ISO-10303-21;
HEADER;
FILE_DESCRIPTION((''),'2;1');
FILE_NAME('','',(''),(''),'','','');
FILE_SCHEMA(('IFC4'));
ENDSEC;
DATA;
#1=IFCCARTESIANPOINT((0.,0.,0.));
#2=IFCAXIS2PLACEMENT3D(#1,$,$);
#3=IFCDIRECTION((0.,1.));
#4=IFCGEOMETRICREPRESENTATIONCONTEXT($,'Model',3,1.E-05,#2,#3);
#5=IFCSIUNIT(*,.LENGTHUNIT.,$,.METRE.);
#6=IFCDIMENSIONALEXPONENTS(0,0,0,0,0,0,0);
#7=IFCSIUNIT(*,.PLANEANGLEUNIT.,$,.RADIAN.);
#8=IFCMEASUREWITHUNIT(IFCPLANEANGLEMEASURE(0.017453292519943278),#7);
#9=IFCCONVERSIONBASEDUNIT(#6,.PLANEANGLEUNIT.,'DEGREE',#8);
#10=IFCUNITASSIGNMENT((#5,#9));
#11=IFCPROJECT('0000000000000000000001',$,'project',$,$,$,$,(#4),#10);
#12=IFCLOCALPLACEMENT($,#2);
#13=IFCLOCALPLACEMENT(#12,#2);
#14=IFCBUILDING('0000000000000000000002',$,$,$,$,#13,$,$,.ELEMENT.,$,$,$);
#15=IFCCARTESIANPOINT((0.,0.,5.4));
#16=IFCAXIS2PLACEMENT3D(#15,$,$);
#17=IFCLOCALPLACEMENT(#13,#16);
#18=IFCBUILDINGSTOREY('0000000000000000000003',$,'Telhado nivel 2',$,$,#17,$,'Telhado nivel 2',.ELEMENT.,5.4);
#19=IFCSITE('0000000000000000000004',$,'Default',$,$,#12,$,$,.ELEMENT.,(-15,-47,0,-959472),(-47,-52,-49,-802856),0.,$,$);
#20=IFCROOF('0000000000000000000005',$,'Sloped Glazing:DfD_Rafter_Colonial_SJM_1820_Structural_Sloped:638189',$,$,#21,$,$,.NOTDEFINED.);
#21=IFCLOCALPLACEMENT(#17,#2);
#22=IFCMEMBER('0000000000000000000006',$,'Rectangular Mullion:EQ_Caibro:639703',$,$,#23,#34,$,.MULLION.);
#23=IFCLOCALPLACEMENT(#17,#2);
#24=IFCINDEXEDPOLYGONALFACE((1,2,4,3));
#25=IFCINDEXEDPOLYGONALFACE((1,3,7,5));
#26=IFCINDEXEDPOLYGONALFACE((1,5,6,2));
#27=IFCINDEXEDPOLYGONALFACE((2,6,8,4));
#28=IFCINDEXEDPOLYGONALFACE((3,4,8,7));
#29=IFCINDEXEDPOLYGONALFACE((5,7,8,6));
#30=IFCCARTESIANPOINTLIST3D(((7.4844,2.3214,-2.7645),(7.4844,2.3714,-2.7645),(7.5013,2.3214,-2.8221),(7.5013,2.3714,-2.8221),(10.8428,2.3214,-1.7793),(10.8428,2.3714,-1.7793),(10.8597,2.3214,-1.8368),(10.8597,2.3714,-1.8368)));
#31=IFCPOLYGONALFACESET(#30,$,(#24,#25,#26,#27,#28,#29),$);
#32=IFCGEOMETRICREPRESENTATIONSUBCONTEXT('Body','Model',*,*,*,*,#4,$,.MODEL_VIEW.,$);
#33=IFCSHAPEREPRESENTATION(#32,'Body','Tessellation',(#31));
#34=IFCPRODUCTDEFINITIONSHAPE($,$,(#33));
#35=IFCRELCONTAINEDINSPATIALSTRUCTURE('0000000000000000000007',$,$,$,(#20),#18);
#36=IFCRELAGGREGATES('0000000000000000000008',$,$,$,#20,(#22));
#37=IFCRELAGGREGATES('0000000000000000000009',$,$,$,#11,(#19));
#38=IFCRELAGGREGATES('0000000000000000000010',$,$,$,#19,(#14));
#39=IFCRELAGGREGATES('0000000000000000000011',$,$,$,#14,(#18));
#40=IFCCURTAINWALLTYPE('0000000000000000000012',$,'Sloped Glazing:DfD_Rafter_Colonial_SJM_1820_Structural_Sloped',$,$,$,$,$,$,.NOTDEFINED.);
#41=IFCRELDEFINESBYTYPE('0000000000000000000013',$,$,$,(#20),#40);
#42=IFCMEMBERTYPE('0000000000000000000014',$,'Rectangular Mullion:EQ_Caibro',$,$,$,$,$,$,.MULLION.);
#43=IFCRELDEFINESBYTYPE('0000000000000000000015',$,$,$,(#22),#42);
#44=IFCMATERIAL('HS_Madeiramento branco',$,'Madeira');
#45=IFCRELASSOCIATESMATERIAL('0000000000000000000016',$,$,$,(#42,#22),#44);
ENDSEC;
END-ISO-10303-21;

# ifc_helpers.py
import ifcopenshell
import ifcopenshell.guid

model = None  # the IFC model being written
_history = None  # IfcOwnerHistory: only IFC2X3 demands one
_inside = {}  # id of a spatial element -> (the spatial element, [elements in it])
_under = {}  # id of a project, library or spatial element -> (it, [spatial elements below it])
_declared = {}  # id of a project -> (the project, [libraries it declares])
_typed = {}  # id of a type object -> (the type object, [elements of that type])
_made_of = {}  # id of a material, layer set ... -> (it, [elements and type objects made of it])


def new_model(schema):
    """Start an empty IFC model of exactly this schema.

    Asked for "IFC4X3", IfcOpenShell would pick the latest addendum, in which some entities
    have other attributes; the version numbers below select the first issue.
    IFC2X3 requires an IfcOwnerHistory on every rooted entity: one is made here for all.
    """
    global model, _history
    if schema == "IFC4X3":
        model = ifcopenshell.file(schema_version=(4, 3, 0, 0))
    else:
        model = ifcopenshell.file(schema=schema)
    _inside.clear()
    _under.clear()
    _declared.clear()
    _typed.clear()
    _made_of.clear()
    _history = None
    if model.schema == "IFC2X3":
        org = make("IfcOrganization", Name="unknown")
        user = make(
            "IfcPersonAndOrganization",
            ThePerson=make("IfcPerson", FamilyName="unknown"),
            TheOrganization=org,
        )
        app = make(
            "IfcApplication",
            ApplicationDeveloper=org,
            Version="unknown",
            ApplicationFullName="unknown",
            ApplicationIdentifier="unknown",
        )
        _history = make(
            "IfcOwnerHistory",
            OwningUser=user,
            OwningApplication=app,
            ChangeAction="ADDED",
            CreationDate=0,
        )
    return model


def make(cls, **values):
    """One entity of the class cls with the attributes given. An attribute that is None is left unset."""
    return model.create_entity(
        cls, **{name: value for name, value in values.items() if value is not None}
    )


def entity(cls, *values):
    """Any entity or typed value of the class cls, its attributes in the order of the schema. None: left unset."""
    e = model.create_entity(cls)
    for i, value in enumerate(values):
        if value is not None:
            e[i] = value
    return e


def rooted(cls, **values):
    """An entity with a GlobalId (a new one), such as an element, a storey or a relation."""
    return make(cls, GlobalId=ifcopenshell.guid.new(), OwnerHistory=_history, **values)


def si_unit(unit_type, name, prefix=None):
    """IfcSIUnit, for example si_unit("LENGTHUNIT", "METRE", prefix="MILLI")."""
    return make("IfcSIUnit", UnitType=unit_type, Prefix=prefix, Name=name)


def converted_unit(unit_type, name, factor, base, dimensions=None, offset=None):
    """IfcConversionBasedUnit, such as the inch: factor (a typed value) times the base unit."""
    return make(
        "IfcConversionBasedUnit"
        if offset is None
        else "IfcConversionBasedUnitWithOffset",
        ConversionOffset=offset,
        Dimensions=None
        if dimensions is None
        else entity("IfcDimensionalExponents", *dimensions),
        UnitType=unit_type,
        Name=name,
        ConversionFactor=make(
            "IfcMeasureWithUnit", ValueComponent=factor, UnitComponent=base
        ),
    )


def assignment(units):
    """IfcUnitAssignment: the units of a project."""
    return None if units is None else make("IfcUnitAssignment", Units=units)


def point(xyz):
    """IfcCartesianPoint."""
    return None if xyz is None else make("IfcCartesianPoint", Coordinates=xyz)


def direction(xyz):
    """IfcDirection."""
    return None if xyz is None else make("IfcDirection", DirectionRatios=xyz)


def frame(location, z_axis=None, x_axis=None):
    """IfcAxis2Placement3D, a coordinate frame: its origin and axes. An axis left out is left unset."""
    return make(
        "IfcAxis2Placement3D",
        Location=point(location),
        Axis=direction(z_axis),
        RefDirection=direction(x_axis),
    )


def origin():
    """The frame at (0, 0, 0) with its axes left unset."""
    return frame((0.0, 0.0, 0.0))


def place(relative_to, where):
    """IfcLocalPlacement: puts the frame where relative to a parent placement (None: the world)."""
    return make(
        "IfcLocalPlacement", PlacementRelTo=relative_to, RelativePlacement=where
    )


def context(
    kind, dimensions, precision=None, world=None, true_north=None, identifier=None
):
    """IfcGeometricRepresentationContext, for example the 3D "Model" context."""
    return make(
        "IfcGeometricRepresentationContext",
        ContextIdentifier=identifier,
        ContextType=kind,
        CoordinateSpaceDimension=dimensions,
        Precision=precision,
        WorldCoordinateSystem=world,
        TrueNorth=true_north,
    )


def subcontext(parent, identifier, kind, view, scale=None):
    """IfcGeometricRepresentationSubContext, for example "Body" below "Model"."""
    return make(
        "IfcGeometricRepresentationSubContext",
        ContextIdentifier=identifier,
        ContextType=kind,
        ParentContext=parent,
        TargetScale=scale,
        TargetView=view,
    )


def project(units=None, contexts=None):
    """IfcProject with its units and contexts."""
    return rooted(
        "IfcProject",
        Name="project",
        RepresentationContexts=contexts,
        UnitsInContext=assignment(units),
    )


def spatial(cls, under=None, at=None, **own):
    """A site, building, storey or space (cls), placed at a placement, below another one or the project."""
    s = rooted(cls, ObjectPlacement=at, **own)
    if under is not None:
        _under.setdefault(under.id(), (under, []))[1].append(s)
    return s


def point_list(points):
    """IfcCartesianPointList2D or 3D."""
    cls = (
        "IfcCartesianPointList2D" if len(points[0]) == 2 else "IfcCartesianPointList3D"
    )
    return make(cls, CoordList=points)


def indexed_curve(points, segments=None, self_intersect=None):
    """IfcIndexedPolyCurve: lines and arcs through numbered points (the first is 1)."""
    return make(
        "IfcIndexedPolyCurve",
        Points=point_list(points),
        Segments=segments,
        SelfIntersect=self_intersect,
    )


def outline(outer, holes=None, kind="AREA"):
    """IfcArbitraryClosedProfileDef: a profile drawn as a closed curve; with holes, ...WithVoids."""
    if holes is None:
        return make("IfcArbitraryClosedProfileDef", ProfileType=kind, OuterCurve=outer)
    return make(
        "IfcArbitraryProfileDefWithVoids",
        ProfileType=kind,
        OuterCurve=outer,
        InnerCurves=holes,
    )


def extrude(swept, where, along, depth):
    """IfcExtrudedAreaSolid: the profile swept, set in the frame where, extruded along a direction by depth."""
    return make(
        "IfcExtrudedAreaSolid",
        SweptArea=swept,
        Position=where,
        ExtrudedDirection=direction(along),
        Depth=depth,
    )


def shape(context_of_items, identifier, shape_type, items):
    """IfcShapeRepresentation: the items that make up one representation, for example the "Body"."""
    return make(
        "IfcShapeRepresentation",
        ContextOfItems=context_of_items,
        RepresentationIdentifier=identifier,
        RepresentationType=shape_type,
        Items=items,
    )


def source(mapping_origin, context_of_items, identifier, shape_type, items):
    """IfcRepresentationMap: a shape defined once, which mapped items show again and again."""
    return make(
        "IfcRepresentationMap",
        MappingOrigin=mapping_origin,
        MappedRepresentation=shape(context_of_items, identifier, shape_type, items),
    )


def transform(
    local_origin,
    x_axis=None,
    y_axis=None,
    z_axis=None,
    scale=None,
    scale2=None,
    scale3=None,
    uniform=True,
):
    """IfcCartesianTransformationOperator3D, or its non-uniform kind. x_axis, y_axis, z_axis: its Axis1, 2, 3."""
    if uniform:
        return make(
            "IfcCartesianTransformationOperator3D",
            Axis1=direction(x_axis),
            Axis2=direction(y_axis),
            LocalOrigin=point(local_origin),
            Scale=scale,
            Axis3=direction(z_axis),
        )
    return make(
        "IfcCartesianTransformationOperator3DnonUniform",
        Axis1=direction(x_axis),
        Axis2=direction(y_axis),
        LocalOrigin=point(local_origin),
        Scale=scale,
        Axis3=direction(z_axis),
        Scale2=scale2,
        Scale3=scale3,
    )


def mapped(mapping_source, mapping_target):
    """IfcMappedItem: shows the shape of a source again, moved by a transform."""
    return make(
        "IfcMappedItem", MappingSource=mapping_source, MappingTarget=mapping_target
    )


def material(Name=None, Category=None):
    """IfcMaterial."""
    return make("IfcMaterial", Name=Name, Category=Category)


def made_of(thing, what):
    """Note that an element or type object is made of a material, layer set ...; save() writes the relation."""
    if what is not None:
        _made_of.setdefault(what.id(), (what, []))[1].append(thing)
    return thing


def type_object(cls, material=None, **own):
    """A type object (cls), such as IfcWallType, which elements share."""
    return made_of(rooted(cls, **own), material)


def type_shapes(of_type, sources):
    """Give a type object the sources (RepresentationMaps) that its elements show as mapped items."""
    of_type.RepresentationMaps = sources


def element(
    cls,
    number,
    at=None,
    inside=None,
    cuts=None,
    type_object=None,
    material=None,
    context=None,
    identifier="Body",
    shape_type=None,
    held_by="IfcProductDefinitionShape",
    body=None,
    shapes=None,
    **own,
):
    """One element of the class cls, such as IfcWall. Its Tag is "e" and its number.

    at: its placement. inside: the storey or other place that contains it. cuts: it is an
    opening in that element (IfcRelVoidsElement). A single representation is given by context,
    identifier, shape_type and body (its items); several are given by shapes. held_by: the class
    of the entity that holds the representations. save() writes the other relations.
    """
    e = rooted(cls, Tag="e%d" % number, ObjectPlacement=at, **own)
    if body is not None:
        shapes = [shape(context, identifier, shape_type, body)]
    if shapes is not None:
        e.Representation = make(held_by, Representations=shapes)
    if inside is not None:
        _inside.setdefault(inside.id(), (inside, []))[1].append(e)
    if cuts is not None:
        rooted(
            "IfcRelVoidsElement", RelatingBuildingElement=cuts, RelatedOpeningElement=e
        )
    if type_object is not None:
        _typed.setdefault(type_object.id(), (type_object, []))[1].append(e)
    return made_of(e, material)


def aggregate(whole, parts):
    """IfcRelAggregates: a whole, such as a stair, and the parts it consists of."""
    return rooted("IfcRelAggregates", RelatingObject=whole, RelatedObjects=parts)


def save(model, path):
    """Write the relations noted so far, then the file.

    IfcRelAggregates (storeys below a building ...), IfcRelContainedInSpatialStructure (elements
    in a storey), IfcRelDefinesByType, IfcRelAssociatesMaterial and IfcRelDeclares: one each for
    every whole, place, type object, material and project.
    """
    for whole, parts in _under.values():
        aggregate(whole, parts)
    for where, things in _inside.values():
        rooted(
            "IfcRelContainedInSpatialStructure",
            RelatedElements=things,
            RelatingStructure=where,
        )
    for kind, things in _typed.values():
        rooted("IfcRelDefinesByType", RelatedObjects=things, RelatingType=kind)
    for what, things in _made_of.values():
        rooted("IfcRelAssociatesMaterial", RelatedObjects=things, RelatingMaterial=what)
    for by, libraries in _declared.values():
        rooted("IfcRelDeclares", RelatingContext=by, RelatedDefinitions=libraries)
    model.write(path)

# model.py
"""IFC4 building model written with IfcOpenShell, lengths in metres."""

from ifc_helpers import new_model, entity, si_unit, converted_unit, direction, frame, origin, place, context, subcontext, project, spatial, indexed_curve, outline, extrude, source, transform, mapped, material, type_object, type_shapes, element, aggregate, save


model = new_model("IFC4")

# Units and contexts
model_context = context("Model", 3, precision=1e-05, world=origin(), true_north=direction((0.0, 1.0)))
body_context = subcontext(model_context, "Body", "Model", "MODEL_VIEW")
ifc_project = project(units=[si_unit("LENGTHUNIT", "METRE"), converted_unit("PLANEANGLEUNIT", "DEGREE", entity("IfcPlaneAngleMeasure", 0.017453292519943278), si_unit("PLANEANGLEUNIT", "RADIAN"), dimensions=[0, 0, 0, 0, 0, 0, 0])], contexts=[model_context])

# Site, building, storey
site_placement = place(None, origin())
site = spatial("IfcSite", under=ifc_project, at=site_placement, Name="Default", CompositionType="ELEMENT", RefLatitude=(-15, -47, 0, -959472), RefLongitude=(-47, -52, -49, -802856), RefElevation=0.0)
building_placement = place(site_placement, origin())
building = spatial("IfcBuilding", under=site, at=building_placement, CompositionType="ELEMENT")
storey_placement = place(building_placement, frame((0.0, 0.0, 5.4)))
storey = spatial("IfcBuildingStorey", under=building, at=storey_placement, Name="Telhado nivel 2", LongName="Telhado nivel 2", CompositionType="ELEMENT", Elevation=5.4)

# Roof, member
curtain_wall_type = type_object("IfcCurtainWallType", Name="Sloped Glazing:DfD_Rafter_Colonial_SJM_1820_Structural_Sloped", PredefinedType="NOTDEFINED")
ifc_material = material(Name="HS_Madeiramento branco", Category="Madeira")
roof_1_placement = place(storey_placement, frame((0.0, 0.0, -5.4)))
roof_1 = element("IfcRoof", 1, at=roof_1_placement, inside=storey, type_object=curtain_wall_type, Name="Sloped Glazing:DfD_Rafter_Colonial_SJM_1820_Structural_Sloped:638189", PredefinedType="NOTDEFINED")
member_type_1 = type_object("IfcMemberType", Name="Rectangular Mullion:EQ_Caibro", PredefinedType="MULLION", material=ifc_material)
shared_shape_1 = source(origin(), body_context, "Body", "SweptSolid", [
    extrude(outline(indexed_curve([(-0.025, -0.03), (0.025, -0.03), (0.025, 0.03), (-0.025, 0.03), (-0.025, -0.03)], self_intersect=False)), frame((0.0, -0.03, -3.5), z_axis=(0.0, 0.0, 1.0), x_axis=(-1.0, 0.0, 0.0)), (0.0, 0.0, 1.0), 3.5),
])
type_shapes(member_type_1, [shared_shape_1])
member_1_placement = place(roof_1_placement, frame((10.8597, 2.3464, 3.5632), z_axis=(0.95956, 0.0, 0.281504), x_axis=(0.0, -1.0, 0.0)))
member_1 = element("IfcMember", 2, at=member_1_placement, type_object=member_type_1, material=ifc_material, Name="Rectangular Mullion:EQ_Caibro:639703", PredefinedType="MULLION", context=body_context, shape_type="MappedRepresentation", body=[
    mapped(shared_shape_1, transform((0.0, 0.0, 0.0), scale=1.0)),
])
aggregate(roof_1, [member_1])

save(model, "model.ifc")
